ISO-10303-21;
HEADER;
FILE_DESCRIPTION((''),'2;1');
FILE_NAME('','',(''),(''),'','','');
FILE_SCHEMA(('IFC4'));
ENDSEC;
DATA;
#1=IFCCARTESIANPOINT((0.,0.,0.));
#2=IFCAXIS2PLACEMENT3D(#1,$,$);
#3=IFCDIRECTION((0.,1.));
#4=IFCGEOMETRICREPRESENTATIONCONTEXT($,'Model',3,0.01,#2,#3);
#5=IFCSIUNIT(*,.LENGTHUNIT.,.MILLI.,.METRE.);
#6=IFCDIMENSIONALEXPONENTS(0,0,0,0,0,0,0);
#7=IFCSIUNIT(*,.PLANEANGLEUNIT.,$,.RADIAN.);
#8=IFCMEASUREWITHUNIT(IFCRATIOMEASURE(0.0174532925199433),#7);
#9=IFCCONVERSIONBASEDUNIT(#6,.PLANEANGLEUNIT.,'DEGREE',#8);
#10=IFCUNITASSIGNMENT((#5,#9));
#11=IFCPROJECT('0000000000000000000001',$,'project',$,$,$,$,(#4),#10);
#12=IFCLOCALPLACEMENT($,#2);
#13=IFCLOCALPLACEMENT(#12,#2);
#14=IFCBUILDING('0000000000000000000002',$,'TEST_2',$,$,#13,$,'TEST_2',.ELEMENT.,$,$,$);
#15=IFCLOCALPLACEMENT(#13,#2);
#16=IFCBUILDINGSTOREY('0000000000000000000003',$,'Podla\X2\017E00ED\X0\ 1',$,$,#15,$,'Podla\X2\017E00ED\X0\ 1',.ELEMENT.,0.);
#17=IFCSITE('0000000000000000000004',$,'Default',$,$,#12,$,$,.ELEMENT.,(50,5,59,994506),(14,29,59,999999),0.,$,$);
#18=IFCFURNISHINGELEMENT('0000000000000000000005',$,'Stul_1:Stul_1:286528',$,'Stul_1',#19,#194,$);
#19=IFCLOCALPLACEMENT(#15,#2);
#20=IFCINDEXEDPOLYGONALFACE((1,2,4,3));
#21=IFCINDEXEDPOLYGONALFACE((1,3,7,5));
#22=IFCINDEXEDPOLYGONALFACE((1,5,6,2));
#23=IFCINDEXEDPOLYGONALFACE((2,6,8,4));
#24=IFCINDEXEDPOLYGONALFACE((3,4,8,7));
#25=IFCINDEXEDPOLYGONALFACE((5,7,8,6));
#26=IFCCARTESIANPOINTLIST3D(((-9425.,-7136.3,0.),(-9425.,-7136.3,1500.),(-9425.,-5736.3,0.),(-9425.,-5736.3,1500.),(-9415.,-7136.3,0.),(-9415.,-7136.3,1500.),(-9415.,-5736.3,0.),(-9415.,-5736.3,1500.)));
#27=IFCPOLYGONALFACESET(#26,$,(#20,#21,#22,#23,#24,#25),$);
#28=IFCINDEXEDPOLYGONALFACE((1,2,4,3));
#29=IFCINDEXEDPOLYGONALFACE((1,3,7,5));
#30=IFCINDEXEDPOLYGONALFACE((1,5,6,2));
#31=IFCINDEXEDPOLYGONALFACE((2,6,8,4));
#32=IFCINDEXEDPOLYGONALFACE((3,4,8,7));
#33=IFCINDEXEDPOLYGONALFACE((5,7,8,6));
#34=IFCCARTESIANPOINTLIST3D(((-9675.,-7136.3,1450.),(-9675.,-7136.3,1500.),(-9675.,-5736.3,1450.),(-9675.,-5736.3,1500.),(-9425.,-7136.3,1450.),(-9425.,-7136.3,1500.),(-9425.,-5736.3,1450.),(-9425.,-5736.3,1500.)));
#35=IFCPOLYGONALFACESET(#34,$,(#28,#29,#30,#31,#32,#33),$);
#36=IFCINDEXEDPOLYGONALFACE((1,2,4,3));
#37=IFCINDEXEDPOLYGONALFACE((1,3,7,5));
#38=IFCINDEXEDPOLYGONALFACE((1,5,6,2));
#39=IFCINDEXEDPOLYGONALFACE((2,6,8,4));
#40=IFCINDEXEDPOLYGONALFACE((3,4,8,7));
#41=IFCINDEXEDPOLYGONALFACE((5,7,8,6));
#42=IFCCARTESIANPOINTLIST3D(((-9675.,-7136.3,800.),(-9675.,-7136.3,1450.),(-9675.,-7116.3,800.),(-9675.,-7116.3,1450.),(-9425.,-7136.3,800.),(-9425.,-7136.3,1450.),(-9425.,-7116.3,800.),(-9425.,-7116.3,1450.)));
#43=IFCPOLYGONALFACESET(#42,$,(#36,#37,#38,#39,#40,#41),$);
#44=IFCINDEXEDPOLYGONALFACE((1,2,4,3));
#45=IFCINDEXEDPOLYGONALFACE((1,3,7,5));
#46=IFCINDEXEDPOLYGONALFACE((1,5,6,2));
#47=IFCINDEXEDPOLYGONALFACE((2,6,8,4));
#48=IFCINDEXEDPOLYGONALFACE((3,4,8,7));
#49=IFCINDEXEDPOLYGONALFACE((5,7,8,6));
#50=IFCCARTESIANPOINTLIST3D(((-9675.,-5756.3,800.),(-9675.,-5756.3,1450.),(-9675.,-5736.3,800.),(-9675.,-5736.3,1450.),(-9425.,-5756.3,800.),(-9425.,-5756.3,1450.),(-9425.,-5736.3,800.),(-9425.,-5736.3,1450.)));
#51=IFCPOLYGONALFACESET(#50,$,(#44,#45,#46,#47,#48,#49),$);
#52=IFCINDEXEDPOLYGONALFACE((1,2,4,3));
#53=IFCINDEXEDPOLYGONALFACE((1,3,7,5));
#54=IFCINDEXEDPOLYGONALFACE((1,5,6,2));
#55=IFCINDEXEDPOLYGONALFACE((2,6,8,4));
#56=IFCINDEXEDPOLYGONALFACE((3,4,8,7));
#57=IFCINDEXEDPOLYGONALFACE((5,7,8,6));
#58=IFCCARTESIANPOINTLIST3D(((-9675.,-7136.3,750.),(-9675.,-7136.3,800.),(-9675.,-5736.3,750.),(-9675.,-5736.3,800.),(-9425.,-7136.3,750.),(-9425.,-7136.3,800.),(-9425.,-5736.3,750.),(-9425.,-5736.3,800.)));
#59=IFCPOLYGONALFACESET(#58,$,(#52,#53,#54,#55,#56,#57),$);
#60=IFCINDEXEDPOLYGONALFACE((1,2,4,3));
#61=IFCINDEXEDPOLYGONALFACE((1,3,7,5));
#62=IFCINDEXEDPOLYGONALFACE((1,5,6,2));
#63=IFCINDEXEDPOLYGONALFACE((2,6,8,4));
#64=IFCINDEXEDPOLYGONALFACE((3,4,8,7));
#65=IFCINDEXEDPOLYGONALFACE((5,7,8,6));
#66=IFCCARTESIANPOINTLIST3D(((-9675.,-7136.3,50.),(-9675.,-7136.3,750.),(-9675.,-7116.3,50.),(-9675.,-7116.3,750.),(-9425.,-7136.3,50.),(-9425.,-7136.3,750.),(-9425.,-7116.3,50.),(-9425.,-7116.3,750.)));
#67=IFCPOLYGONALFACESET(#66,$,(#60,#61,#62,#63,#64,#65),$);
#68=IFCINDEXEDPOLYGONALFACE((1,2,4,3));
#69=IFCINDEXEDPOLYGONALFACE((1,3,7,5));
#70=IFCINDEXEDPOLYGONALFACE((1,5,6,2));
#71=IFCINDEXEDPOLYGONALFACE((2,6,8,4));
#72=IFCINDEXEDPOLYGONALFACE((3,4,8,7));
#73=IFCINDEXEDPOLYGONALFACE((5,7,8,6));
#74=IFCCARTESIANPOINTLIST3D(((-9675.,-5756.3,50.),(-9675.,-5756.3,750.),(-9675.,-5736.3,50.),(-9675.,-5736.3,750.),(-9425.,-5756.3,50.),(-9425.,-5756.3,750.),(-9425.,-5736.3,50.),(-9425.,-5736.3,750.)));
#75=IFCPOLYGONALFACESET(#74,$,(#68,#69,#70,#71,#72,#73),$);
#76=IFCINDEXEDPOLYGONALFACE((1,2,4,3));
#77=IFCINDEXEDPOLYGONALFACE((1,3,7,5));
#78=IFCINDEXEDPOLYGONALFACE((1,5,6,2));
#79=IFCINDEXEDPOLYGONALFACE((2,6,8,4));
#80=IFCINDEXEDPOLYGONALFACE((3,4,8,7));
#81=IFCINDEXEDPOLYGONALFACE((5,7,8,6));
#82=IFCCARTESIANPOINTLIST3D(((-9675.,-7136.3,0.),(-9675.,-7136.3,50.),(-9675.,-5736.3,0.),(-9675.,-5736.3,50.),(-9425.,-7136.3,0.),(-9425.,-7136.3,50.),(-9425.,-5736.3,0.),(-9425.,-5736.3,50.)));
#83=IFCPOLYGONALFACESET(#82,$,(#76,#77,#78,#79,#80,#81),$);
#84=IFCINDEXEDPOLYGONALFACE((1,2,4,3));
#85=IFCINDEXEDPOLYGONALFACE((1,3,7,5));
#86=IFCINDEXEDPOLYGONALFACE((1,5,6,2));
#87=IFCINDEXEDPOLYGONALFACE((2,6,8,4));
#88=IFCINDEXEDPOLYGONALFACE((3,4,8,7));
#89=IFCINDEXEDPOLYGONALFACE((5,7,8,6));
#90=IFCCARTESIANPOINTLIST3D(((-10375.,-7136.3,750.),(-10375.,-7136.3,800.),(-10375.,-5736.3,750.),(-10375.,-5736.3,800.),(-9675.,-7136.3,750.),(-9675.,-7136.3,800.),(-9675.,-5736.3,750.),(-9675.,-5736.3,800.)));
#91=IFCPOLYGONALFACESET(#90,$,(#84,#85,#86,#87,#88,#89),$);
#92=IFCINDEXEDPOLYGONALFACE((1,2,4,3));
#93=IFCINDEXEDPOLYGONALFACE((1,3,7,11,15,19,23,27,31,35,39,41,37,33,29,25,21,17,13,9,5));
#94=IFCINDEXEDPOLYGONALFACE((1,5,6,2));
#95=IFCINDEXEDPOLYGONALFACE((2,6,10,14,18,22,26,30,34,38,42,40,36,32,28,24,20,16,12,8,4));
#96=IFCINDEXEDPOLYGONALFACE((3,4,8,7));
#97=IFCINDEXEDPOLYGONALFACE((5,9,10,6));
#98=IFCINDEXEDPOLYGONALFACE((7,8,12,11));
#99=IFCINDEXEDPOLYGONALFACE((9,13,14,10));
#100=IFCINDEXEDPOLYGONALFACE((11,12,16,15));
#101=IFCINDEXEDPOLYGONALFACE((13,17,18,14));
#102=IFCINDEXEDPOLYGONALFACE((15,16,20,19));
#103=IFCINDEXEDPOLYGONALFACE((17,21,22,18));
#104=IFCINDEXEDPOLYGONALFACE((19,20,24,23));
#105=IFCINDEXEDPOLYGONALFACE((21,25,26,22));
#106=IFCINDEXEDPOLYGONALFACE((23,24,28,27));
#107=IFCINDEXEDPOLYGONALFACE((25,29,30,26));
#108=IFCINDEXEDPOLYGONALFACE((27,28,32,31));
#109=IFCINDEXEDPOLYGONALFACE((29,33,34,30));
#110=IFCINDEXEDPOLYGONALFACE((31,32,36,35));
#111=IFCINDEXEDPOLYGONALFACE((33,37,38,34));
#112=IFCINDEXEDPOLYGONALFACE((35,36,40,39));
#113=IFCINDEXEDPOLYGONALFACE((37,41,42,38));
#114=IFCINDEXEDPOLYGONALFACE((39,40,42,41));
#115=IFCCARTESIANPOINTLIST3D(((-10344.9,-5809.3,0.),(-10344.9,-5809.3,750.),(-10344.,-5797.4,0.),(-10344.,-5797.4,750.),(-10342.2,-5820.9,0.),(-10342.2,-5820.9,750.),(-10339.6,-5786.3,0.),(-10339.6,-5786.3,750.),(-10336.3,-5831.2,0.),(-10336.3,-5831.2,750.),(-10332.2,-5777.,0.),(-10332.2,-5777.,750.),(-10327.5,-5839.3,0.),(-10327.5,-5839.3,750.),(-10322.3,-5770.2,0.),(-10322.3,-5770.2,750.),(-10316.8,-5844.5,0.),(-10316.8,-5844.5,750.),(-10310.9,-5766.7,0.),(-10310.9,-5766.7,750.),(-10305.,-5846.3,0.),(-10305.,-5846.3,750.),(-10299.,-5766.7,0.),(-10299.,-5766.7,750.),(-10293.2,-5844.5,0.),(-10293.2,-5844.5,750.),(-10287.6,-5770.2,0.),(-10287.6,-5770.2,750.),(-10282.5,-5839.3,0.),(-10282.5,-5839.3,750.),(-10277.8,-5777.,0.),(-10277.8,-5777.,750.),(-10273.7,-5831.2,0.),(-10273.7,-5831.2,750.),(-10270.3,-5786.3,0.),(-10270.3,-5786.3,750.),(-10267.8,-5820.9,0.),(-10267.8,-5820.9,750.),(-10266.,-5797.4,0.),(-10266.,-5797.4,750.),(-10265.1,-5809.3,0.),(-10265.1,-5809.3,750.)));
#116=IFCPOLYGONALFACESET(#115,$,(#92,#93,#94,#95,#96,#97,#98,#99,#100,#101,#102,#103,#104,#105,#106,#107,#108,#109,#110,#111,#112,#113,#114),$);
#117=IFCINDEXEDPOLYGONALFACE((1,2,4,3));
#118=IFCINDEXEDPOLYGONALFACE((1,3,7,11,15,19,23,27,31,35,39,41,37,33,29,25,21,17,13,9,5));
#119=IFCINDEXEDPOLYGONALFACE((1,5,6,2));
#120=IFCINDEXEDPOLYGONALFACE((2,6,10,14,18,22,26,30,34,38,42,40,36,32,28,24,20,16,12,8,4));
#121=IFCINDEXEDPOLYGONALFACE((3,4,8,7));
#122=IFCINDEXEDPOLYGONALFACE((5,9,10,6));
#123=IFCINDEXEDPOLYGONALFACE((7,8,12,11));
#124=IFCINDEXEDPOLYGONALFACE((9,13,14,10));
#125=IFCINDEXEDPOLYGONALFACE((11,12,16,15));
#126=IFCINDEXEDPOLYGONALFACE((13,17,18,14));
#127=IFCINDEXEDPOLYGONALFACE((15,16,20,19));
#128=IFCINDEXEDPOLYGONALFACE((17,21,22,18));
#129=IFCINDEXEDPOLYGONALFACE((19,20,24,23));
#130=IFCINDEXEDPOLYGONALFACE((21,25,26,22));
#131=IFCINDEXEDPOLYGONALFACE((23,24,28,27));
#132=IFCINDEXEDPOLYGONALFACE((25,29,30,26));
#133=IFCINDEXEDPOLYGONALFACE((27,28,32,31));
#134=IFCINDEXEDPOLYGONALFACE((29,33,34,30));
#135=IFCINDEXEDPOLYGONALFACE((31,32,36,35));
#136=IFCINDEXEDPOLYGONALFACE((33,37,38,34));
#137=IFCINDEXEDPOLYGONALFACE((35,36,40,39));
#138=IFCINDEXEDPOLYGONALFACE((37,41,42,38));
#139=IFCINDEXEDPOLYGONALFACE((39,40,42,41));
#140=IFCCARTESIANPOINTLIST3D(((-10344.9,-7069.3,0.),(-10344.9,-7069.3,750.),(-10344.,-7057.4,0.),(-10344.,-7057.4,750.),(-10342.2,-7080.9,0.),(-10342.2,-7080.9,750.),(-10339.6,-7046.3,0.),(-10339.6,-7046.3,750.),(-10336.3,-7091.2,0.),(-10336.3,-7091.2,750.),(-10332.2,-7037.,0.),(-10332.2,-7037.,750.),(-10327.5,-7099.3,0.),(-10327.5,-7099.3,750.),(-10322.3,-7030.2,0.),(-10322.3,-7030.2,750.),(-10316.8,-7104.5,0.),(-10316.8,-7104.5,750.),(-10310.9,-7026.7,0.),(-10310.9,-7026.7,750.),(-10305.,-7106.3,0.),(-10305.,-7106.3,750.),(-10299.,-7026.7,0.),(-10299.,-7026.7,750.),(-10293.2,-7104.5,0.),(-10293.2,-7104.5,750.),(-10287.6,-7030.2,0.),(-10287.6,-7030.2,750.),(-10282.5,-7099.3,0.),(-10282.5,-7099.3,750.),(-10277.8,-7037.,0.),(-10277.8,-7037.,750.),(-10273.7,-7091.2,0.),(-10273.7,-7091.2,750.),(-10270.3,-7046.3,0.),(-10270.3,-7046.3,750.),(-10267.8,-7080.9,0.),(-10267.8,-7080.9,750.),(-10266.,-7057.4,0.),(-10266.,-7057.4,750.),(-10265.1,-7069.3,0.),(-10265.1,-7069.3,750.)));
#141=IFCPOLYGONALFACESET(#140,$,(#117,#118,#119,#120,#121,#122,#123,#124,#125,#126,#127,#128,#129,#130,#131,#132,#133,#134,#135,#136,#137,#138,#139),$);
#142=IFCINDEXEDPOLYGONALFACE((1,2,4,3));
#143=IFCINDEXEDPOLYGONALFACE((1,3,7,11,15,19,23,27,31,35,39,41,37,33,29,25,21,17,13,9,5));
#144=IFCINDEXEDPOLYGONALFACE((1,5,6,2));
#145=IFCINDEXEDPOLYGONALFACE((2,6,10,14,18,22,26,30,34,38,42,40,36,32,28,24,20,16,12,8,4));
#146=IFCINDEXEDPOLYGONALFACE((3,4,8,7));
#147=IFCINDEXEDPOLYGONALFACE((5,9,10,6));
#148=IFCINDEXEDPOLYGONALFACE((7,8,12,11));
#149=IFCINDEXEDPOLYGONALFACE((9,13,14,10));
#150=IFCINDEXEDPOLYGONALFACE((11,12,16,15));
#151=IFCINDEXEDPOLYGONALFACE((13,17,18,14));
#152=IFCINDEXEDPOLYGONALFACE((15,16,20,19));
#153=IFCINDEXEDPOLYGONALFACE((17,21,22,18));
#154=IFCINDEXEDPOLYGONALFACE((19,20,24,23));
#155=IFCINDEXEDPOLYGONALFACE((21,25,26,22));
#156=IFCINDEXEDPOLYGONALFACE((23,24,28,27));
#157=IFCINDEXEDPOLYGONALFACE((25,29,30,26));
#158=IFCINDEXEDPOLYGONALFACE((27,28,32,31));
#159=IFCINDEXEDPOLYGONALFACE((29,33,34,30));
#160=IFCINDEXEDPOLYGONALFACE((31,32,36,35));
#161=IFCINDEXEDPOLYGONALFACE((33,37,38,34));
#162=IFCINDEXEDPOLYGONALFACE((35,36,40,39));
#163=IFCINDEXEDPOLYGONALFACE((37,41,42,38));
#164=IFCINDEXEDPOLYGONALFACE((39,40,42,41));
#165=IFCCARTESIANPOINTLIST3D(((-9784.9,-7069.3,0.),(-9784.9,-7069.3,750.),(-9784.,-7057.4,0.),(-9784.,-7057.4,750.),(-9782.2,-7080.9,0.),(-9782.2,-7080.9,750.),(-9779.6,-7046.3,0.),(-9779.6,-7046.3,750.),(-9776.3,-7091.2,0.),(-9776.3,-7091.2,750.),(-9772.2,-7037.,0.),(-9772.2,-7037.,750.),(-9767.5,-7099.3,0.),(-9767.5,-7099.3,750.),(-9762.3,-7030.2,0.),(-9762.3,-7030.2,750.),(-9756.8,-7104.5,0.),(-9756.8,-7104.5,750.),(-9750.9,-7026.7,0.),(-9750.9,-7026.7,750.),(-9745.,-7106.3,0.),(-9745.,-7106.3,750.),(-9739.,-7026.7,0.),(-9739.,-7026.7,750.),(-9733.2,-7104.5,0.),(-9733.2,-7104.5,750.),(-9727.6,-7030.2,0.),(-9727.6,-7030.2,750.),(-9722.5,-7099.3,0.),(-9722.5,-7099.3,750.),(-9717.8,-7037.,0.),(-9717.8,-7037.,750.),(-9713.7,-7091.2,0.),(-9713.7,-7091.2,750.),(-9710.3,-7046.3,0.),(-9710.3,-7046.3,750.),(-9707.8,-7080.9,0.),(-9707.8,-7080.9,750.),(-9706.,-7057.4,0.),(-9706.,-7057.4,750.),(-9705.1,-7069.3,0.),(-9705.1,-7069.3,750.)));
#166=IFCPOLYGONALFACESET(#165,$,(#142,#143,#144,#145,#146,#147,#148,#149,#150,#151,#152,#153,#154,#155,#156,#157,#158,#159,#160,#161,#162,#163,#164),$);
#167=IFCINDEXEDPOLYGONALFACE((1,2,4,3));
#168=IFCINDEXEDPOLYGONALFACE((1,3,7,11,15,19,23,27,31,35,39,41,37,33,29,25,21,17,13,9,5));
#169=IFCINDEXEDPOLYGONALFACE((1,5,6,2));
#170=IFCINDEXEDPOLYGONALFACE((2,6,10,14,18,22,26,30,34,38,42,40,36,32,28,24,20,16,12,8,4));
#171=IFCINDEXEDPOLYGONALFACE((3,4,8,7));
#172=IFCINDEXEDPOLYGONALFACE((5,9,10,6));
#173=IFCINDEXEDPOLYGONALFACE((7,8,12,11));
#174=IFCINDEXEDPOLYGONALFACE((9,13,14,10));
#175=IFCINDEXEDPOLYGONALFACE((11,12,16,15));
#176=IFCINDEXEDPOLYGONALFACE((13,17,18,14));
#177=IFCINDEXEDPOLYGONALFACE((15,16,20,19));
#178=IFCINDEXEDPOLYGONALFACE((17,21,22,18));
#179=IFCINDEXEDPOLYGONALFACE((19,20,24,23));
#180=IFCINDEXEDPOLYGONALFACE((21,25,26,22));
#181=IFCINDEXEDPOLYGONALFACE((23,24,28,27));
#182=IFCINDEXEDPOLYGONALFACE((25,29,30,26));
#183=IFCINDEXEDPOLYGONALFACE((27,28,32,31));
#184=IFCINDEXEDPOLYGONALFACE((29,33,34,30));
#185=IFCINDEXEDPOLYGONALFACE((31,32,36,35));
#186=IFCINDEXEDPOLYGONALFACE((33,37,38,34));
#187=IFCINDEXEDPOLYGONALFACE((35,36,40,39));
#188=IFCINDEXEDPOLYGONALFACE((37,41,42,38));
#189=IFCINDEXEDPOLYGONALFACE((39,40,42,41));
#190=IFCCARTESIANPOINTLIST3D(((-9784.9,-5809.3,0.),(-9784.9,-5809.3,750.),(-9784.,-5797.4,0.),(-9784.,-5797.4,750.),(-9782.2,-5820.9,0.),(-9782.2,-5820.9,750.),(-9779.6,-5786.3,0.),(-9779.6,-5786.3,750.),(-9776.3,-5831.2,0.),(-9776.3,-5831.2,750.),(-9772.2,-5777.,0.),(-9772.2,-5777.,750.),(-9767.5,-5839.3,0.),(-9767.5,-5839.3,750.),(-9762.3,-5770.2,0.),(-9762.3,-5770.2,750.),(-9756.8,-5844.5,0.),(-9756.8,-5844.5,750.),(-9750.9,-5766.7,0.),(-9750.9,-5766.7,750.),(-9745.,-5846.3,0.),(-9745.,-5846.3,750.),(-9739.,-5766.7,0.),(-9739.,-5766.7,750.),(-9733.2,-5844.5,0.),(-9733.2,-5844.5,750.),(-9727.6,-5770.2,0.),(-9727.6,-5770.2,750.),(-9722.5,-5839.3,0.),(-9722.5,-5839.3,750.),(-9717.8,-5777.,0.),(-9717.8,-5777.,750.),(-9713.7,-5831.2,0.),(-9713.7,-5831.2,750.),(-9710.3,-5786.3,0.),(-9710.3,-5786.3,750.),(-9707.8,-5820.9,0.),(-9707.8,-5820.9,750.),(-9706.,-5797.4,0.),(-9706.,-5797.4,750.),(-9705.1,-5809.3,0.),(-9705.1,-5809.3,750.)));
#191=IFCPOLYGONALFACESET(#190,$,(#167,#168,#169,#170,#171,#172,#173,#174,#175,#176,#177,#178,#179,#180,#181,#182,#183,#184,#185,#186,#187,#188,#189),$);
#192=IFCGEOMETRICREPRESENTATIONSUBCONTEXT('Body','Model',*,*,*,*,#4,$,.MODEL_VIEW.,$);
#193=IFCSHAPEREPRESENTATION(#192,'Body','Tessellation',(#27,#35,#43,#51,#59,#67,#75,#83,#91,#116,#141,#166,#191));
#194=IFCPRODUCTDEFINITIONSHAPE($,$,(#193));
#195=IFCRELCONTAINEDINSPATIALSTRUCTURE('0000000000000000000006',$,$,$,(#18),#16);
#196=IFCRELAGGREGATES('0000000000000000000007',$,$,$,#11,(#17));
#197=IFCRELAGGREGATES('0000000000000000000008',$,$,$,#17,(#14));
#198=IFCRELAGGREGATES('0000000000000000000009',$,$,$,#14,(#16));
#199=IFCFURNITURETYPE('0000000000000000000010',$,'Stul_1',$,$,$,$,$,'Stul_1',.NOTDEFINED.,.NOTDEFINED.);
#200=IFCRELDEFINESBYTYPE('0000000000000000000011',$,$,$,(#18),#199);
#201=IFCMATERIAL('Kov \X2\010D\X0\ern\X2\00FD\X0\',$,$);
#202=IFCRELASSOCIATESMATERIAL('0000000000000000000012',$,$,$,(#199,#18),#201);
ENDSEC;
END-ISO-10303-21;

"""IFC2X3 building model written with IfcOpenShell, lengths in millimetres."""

from ifc_helpers import new_model, entity, si_unit, converted_unit, direction, frame, frame_2d, origin, origin_2d_with_axis, place, context, subcontext, project, spatial, rectangle, circle, extrude, source, transform, mapped, material, type_object, type_shapes, element, save


model = new_model("IFC2X3")

# Units and contexts
model_context = context("Model", 3, precision=0.01, world=origin(), true_north=direction((0.0, 1.0)))
body_context = subcontext(model_context, "Body", "Model", "MODEL_VIEW")
ifc_project = project(units=[si_unit("LENGTHUNIT", "METRE", prefix="MILLI"), converted_unit("PLANEANGLEUNIT", "DEGREE", entity("IfcRatioMeasure", 0.0174532925199433), si_unit("PLANEANGLEUNIT", "RADIAN"), dimensions=[0, 0, 0, 0, 0, 0, 0])], contexts=[model_context])

# Site, building, storey
site_placement = place(None, origin())
site = spatial("IfcSite", under=ifc_project, at=site_placement, Name="Default", CompositionType="ELEMENT", RefLatitude=(50, 5, 59, 994506), RefLongitude=(14, 29, 59, 999999), RefElevation=0.0)
building_placement = place(site_placement, origin())
building = spatial("IfcBuilding", under=site, at=building_placement, Name="TEST_2", LongName="TEST_2", CompositionType="ELEMENT")
storey_placement = place(building_placement, origin())
storey = spatial("IfcBuildingStorey", under=building, at=storey_placement, Name="Podlaží 1", LongName="Podlaží 1", CompositionType="ELEMENT", Elevation=0.0)

# Furnishing element
ifc_material_1 = material(Name="Kov černý")
furniture_type = type_object("IfcFurnitureType", Name="Stul_1", ElementType="Stul_1", material=ifc_material_1)
shared_shape_1 = source(origin(), body_context, "Body", "SweptSolid", [
    extrude(rectangle(XDim=1400.0, YDim=10.0, at=origin_2d_with_axis()), frame((0.0, 605.0, 0.0), z_axis=(0.0, 0.0, 1.0), x_axis=(-1.0, 0.0, 0.0)), (0.0, 0.0, 1.0), 1500.0),
    extrude(rectangle(XDim=1400.0, YDim=250.0, at=frame_2d((0.0, 0.0), x_axis=(1.0, 0.0))), frame((0.0, 475.0, 1450.0), z_axis=(0.0, 0.0, 1.0), x_axis=(-1.0, 0.0, 0.0)), (0.0, 0.0, 1.0), 50.0),
    extrude(rectangle(XDim=20.0, YDim=250.0, at=origin_2d_with_axis()), frame((690.0, 475.0, 800.0), z_axis=(0.0, 0.0, 1.0), x_axis=(-1.0, 0.0, 0.0)), (0.0, 0.0, 1.0), 650.0),
    extrude(rectangle(XDim=20.0, YDim=250.0, at=frame_2d((0.0, 0.0), x_axis=(1.0, 0.0))), frame((-690.0, 475.0, 800.0), z_axis=(0.0, 0.0, 1.0), x_axis=(-1.0, 0.0, 0.0)), (0.0, 0.0, 1.0), 650.0),
    extrude(rectangle(XDim=1400.0, YDim=250.0, at=origin_2d_with_axis()), frame((0.0, 475.0, 750.0), z_axis=(0.0, 0.0, 1.0), x_axis=(-1.0, 0.0, 0.0)), (0.0, 0.0, 1.0), 50.0),
    extrude(rectangle(XDim=20.0, YDim=250.0, at=origin_2d_with_axis()), frame((690.0, 475.0, 50.0), z_axis=(0.0, 0.0, 1.0), x_axis=(-1.0, 0.0, 0.0)), (0.0, 0.0, 1.0), 700.0),
    extrude(rectangle(XDim=20.0, YDim=250.0, at=frame_2d((0.0, 0.0), x_axis=(1.0, 0.0))), frame((-690.0, 475.0, 50.0), z_axis=(0.0, 0.0, 1.0), x_axis=(-1.0, 0.0, 0.0)), (0.0, 0.0, 1.0), 700.0),
    extrude(rectangle(XDim=1400.0, YDim=250.0, at=origin_2d_with_axis()), frame((0.0, 475.0, 0.0), z_axis=(0.0, 0.0, 1.0), x_axis=(-1.0, 0.0, 0.0)), (0.0, 0.0, 1.0), 50.0),
    extrude(rectangle(XDim=1400.0, YDim=700.0, at=origin_2d_with_axis()), frame((0.0, 0.0, 750.0), z_axis=(0.0, 0.0, 1.0), x_axis=(-1.0, 0.0, 0.0)), (0.0, 0.0, 1.0), 50.0),
    extrude(circle(Radius=40.0, at=frame_2d((0.0, 0.0), x_axis=(1.0, 0.0))), frame((-630.0, -280.0, 0.0)), (0.0, 0.0, 1.0), 750.0),
    extrude(circle(Radius=40.0, at=frame_2d((0.0, 0.0), x_axis=(1.0, 0.0))), frame((630.0, -280.0, 0.0)), (0.0, 0.0, 1.0), 750.0),
    extrude(circle(Radius=40.0, at=frame_2d((0.0, 0.0), x_axis=(1.0, 0.0))), frame((630.0, 280.0, 0.0)), (0.0, 0.0, 1.0), 750.0),
    extrude(circle(Radius=40.0, at=frame_2d((0.0, 0.0), x_axis=(1.0, 0.0))), frame((-630.0, 280.0, 0.0)), (0.0, 0.0, 1.0), 750.0),
])
type_shapes(furniture_type, [shared_shape_1])
for number, where, z_axis, x_axis, name in (
    (1, (-10025.0, -6436.3, 0.0), (0.0, 0.0, 1.0), (0.0, -1.0, 0.0), "Stul_1:Stul_1:286528"),
):
    element("IfcFurnishingElement", number, at=place(storey_placement, frame(where, z_axis=z_axis, x_axis=x_axis)), inside=storey, type_object=furniture_type, material=ifc_material_1, Name=name, ObjectType="Stul_1", context=body_context, shape_type="MappedRepresentation", body=[
        mapped(shared_shape_1, transform((0.0, 0.0, 0.0), scale=1.0)),
    ])

save(model, "model.ifc")
